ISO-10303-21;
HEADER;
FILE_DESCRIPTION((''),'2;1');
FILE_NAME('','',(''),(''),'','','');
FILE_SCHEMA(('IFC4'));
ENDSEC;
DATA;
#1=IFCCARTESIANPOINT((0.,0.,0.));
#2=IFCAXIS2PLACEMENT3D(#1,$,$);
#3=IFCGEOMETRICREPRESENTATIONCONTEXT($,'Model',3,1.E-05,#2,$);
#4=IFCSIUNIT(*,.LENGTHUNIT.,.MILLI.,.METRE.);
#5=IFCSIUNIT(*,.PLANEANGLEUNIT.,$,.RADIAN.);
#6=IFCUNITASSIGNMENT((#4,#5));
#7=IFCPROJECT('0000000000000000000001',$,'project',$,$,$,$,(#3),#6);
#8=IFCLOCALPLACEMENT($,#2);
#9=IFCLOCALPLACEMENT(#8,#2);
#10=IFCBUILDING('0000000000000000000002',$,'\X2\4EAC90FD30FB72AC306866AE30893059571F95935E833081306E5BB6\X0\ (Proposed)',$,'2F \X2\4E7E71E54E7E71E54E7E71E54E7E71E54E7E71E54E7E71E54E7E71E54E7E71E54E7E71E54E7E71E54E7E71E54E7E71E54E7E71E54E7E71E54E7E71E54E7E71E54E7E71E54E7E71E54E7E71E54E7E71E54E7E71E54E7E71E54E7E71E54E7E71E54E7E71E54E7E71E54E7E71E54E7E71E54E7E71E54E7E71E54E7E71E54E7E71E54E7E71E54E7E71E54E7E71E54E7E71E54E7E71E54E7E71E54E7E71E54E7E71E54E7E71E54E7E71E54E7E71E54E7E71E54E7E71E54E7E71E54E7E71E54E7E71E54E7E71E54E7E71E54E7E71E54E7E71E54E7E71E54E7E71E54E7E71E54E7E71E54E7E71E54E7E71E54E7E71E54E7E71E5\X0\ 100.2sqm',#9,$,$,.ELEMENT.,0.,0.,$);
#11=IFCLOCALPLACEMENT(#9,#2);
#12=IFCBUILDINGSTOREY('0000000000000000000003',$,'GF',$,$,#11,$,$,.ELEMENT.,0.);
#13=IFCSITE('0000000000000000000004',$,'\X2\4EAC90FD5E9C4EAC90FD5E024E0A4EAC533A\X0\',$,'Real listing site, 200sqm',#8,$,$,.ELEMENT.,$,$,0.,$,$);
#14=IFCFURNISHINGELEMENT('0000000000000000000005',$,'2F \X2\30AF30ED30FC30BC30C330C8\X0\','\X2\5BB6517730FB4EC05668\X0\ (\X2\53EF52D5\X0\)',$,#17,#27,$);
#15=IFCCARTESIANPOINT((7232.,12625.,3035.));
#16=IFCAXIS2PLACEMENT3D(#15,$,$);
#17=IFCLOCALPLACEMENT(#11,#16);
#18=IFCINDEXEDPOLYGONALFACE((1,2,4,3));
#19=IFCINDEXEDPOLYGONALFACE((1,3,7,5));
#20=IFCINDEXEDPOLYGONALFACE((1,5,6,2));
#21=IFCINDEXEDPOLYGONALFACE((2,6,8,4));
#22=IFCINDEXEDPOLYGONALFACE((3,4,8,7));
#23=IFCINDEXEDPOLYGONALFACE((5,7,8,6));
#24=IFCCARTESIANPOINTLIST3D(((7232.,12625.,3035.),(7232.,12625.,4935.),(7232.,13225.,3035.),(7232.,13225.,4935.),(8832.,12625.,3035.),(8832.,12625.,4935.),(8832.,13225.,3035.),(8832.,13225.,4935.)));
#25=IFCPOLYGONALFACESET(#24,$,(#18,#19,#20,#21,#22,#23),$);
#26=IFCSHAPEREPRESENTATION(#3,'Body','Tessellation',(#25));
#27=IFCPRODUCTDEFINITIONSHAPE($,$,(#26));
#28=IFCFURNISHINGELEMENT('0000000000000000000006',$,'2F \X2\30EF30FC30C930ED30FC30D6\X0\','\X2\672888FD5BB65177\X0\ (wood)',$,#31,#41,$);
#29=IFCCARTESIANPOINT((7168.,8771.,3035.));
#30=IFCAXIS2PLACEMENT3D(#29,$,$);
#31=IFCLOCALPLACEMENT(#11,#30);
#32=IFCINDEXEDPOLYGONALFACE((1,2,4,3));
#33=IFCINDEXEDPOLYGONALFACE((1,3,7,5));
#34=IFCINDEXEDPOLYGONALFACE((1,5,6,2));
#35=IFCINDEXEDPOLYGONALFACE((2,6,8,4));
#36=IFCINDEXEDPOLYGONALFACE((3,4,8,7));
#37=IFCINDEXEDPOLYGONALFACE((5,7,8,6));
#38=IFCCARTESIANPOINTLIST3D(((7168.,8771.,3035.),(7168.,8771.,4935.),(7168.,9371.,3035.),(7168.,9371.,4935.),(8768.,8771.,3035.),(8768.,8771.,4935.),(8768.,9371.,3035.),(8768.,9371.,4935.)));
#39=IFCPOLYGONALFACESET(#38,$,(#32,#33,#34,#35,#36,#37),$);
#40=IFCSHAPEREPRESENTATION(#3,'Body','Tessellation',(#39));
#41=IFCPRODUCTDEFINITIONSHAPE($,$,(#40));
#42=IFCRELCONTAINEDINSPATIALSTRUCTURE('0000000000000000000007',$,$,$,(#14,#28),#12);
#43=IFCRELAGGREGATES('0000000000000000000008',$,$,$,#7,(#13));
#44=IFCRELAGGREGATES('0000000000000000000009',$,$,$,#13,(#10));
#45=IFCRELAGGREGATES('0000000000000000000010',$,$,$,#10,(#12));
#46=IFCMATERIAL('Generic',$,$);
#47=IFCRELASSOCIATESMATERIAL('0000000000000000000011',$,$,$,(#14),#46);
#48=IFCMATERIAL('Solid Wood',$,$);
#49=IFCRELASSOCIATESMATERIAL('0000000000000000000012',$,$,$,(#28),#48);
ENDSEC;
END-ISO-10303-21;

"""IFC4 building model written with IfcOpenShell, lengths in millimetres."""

from ifc_helpers import new_model, si_unit, frame, frame_2d, origin, place, context, project, spatial, rectangle, extrude, material, element, save


model = new_model("IFC4")

# Units and contexts
model_context = context("Model", 3, precision=1e-05, world=origin())
ifc_project = project(units=[si_unit("LENGTHUNIT", "METRE", prefix="MILLI"), si_unit("PLANEANGLEUNIT", "RADIAN")], contexts=[model_context])

# Site, building, storey
site_placement = place(None, origin())
site = spatial("IfcSite", under=ifc_project, at=site_placement, Name="京都府京都市上京区", ObjectType="Real listing site, 200sqm", CompositionType="ELEMENT", RefElevation=0.0)
building_placement = place(site_placement, origin())
building = spatial("IfcBuilding", under=site, at=building_placement, Name="京都・犬と暮らす土間広めの家 (Proposed)", ObjectType="2F 乾燥乾燥乾燥乾燥乾燥乾燥乾燥乾燥乾燥乾燥乾燥乾燥乾燥乾燥乾燥乾燥乾燥乾燥乾燥乾燥乾燥乾燥乾燥乾燥乾燥乾燥乾燥乾燥乾燥乾燥乾燥乾燥乾燥乾燥乾燥乾燥乾燥乾燥乾燥乾燥乾燥乾燥乾燥乾燥乾燥乾燥乾燥乾燥乾燥乾燥乾燥乾燥乾燥乾燥乾燥乾燥乾燥乾燥乾燥乾燥 100.2sqm", CompositionType="ELEMENT", ElevationOfRefHeight=0.0, ElevationOfTerrain=0.0)
storey_placement = place(building_placement, origin())
storey = spatial("IfcBuildingStorey", under=building, at=storey_placement, Name="GF", CompositionType="ELEMENT", Elevation=0.0)

# Shared definitions
ifc_material_1 = material(Name="Solid Wood")

# Shared definitions
ifc_material_2 = material(Name="Generic")

# Furnishing elements
furnishing_1_placement = place(storey_placement, frame((7232.0, 12625.0, 3035.0)))
element("IfcFurnishingElement", 1, at=furnishing_1_placement, inside=storey, material=ifc_material_2, Name="2F クローゼット", Description="家具・什器 (可動)", context=model_context, shape_type="SweptSolid", body=[
    extrude(rectangle(XDim=1600.0, YDim=600.0, at=frame_2d((800.0, 300.0))), frame((7232.0, 12625.0, 3035.0)), (0.0, 0.0, 1.0), 1900.0),
])
furnishing_2_placement = place(storey_placement, frame((7168.0, 8771.0, 3035.0)))
element("IfcFurnishingElement", 2, at=furnishing_2_placement, inside=storey, material=ifc_material_1, Name="2F ワードローブ", Description="木製家具 (wood)", context=model_context, shape_type="SweptSolid", body=[
    extrude(rectangle(XDim=1600.0, YDim=600.0, at=frame_2d((800.0, 300.0))), frame((7168.0, 8771.0, 3035.0)), (0.0, 0.0, 1.0), 1900.0),
])

save(model, "model.ifc")
